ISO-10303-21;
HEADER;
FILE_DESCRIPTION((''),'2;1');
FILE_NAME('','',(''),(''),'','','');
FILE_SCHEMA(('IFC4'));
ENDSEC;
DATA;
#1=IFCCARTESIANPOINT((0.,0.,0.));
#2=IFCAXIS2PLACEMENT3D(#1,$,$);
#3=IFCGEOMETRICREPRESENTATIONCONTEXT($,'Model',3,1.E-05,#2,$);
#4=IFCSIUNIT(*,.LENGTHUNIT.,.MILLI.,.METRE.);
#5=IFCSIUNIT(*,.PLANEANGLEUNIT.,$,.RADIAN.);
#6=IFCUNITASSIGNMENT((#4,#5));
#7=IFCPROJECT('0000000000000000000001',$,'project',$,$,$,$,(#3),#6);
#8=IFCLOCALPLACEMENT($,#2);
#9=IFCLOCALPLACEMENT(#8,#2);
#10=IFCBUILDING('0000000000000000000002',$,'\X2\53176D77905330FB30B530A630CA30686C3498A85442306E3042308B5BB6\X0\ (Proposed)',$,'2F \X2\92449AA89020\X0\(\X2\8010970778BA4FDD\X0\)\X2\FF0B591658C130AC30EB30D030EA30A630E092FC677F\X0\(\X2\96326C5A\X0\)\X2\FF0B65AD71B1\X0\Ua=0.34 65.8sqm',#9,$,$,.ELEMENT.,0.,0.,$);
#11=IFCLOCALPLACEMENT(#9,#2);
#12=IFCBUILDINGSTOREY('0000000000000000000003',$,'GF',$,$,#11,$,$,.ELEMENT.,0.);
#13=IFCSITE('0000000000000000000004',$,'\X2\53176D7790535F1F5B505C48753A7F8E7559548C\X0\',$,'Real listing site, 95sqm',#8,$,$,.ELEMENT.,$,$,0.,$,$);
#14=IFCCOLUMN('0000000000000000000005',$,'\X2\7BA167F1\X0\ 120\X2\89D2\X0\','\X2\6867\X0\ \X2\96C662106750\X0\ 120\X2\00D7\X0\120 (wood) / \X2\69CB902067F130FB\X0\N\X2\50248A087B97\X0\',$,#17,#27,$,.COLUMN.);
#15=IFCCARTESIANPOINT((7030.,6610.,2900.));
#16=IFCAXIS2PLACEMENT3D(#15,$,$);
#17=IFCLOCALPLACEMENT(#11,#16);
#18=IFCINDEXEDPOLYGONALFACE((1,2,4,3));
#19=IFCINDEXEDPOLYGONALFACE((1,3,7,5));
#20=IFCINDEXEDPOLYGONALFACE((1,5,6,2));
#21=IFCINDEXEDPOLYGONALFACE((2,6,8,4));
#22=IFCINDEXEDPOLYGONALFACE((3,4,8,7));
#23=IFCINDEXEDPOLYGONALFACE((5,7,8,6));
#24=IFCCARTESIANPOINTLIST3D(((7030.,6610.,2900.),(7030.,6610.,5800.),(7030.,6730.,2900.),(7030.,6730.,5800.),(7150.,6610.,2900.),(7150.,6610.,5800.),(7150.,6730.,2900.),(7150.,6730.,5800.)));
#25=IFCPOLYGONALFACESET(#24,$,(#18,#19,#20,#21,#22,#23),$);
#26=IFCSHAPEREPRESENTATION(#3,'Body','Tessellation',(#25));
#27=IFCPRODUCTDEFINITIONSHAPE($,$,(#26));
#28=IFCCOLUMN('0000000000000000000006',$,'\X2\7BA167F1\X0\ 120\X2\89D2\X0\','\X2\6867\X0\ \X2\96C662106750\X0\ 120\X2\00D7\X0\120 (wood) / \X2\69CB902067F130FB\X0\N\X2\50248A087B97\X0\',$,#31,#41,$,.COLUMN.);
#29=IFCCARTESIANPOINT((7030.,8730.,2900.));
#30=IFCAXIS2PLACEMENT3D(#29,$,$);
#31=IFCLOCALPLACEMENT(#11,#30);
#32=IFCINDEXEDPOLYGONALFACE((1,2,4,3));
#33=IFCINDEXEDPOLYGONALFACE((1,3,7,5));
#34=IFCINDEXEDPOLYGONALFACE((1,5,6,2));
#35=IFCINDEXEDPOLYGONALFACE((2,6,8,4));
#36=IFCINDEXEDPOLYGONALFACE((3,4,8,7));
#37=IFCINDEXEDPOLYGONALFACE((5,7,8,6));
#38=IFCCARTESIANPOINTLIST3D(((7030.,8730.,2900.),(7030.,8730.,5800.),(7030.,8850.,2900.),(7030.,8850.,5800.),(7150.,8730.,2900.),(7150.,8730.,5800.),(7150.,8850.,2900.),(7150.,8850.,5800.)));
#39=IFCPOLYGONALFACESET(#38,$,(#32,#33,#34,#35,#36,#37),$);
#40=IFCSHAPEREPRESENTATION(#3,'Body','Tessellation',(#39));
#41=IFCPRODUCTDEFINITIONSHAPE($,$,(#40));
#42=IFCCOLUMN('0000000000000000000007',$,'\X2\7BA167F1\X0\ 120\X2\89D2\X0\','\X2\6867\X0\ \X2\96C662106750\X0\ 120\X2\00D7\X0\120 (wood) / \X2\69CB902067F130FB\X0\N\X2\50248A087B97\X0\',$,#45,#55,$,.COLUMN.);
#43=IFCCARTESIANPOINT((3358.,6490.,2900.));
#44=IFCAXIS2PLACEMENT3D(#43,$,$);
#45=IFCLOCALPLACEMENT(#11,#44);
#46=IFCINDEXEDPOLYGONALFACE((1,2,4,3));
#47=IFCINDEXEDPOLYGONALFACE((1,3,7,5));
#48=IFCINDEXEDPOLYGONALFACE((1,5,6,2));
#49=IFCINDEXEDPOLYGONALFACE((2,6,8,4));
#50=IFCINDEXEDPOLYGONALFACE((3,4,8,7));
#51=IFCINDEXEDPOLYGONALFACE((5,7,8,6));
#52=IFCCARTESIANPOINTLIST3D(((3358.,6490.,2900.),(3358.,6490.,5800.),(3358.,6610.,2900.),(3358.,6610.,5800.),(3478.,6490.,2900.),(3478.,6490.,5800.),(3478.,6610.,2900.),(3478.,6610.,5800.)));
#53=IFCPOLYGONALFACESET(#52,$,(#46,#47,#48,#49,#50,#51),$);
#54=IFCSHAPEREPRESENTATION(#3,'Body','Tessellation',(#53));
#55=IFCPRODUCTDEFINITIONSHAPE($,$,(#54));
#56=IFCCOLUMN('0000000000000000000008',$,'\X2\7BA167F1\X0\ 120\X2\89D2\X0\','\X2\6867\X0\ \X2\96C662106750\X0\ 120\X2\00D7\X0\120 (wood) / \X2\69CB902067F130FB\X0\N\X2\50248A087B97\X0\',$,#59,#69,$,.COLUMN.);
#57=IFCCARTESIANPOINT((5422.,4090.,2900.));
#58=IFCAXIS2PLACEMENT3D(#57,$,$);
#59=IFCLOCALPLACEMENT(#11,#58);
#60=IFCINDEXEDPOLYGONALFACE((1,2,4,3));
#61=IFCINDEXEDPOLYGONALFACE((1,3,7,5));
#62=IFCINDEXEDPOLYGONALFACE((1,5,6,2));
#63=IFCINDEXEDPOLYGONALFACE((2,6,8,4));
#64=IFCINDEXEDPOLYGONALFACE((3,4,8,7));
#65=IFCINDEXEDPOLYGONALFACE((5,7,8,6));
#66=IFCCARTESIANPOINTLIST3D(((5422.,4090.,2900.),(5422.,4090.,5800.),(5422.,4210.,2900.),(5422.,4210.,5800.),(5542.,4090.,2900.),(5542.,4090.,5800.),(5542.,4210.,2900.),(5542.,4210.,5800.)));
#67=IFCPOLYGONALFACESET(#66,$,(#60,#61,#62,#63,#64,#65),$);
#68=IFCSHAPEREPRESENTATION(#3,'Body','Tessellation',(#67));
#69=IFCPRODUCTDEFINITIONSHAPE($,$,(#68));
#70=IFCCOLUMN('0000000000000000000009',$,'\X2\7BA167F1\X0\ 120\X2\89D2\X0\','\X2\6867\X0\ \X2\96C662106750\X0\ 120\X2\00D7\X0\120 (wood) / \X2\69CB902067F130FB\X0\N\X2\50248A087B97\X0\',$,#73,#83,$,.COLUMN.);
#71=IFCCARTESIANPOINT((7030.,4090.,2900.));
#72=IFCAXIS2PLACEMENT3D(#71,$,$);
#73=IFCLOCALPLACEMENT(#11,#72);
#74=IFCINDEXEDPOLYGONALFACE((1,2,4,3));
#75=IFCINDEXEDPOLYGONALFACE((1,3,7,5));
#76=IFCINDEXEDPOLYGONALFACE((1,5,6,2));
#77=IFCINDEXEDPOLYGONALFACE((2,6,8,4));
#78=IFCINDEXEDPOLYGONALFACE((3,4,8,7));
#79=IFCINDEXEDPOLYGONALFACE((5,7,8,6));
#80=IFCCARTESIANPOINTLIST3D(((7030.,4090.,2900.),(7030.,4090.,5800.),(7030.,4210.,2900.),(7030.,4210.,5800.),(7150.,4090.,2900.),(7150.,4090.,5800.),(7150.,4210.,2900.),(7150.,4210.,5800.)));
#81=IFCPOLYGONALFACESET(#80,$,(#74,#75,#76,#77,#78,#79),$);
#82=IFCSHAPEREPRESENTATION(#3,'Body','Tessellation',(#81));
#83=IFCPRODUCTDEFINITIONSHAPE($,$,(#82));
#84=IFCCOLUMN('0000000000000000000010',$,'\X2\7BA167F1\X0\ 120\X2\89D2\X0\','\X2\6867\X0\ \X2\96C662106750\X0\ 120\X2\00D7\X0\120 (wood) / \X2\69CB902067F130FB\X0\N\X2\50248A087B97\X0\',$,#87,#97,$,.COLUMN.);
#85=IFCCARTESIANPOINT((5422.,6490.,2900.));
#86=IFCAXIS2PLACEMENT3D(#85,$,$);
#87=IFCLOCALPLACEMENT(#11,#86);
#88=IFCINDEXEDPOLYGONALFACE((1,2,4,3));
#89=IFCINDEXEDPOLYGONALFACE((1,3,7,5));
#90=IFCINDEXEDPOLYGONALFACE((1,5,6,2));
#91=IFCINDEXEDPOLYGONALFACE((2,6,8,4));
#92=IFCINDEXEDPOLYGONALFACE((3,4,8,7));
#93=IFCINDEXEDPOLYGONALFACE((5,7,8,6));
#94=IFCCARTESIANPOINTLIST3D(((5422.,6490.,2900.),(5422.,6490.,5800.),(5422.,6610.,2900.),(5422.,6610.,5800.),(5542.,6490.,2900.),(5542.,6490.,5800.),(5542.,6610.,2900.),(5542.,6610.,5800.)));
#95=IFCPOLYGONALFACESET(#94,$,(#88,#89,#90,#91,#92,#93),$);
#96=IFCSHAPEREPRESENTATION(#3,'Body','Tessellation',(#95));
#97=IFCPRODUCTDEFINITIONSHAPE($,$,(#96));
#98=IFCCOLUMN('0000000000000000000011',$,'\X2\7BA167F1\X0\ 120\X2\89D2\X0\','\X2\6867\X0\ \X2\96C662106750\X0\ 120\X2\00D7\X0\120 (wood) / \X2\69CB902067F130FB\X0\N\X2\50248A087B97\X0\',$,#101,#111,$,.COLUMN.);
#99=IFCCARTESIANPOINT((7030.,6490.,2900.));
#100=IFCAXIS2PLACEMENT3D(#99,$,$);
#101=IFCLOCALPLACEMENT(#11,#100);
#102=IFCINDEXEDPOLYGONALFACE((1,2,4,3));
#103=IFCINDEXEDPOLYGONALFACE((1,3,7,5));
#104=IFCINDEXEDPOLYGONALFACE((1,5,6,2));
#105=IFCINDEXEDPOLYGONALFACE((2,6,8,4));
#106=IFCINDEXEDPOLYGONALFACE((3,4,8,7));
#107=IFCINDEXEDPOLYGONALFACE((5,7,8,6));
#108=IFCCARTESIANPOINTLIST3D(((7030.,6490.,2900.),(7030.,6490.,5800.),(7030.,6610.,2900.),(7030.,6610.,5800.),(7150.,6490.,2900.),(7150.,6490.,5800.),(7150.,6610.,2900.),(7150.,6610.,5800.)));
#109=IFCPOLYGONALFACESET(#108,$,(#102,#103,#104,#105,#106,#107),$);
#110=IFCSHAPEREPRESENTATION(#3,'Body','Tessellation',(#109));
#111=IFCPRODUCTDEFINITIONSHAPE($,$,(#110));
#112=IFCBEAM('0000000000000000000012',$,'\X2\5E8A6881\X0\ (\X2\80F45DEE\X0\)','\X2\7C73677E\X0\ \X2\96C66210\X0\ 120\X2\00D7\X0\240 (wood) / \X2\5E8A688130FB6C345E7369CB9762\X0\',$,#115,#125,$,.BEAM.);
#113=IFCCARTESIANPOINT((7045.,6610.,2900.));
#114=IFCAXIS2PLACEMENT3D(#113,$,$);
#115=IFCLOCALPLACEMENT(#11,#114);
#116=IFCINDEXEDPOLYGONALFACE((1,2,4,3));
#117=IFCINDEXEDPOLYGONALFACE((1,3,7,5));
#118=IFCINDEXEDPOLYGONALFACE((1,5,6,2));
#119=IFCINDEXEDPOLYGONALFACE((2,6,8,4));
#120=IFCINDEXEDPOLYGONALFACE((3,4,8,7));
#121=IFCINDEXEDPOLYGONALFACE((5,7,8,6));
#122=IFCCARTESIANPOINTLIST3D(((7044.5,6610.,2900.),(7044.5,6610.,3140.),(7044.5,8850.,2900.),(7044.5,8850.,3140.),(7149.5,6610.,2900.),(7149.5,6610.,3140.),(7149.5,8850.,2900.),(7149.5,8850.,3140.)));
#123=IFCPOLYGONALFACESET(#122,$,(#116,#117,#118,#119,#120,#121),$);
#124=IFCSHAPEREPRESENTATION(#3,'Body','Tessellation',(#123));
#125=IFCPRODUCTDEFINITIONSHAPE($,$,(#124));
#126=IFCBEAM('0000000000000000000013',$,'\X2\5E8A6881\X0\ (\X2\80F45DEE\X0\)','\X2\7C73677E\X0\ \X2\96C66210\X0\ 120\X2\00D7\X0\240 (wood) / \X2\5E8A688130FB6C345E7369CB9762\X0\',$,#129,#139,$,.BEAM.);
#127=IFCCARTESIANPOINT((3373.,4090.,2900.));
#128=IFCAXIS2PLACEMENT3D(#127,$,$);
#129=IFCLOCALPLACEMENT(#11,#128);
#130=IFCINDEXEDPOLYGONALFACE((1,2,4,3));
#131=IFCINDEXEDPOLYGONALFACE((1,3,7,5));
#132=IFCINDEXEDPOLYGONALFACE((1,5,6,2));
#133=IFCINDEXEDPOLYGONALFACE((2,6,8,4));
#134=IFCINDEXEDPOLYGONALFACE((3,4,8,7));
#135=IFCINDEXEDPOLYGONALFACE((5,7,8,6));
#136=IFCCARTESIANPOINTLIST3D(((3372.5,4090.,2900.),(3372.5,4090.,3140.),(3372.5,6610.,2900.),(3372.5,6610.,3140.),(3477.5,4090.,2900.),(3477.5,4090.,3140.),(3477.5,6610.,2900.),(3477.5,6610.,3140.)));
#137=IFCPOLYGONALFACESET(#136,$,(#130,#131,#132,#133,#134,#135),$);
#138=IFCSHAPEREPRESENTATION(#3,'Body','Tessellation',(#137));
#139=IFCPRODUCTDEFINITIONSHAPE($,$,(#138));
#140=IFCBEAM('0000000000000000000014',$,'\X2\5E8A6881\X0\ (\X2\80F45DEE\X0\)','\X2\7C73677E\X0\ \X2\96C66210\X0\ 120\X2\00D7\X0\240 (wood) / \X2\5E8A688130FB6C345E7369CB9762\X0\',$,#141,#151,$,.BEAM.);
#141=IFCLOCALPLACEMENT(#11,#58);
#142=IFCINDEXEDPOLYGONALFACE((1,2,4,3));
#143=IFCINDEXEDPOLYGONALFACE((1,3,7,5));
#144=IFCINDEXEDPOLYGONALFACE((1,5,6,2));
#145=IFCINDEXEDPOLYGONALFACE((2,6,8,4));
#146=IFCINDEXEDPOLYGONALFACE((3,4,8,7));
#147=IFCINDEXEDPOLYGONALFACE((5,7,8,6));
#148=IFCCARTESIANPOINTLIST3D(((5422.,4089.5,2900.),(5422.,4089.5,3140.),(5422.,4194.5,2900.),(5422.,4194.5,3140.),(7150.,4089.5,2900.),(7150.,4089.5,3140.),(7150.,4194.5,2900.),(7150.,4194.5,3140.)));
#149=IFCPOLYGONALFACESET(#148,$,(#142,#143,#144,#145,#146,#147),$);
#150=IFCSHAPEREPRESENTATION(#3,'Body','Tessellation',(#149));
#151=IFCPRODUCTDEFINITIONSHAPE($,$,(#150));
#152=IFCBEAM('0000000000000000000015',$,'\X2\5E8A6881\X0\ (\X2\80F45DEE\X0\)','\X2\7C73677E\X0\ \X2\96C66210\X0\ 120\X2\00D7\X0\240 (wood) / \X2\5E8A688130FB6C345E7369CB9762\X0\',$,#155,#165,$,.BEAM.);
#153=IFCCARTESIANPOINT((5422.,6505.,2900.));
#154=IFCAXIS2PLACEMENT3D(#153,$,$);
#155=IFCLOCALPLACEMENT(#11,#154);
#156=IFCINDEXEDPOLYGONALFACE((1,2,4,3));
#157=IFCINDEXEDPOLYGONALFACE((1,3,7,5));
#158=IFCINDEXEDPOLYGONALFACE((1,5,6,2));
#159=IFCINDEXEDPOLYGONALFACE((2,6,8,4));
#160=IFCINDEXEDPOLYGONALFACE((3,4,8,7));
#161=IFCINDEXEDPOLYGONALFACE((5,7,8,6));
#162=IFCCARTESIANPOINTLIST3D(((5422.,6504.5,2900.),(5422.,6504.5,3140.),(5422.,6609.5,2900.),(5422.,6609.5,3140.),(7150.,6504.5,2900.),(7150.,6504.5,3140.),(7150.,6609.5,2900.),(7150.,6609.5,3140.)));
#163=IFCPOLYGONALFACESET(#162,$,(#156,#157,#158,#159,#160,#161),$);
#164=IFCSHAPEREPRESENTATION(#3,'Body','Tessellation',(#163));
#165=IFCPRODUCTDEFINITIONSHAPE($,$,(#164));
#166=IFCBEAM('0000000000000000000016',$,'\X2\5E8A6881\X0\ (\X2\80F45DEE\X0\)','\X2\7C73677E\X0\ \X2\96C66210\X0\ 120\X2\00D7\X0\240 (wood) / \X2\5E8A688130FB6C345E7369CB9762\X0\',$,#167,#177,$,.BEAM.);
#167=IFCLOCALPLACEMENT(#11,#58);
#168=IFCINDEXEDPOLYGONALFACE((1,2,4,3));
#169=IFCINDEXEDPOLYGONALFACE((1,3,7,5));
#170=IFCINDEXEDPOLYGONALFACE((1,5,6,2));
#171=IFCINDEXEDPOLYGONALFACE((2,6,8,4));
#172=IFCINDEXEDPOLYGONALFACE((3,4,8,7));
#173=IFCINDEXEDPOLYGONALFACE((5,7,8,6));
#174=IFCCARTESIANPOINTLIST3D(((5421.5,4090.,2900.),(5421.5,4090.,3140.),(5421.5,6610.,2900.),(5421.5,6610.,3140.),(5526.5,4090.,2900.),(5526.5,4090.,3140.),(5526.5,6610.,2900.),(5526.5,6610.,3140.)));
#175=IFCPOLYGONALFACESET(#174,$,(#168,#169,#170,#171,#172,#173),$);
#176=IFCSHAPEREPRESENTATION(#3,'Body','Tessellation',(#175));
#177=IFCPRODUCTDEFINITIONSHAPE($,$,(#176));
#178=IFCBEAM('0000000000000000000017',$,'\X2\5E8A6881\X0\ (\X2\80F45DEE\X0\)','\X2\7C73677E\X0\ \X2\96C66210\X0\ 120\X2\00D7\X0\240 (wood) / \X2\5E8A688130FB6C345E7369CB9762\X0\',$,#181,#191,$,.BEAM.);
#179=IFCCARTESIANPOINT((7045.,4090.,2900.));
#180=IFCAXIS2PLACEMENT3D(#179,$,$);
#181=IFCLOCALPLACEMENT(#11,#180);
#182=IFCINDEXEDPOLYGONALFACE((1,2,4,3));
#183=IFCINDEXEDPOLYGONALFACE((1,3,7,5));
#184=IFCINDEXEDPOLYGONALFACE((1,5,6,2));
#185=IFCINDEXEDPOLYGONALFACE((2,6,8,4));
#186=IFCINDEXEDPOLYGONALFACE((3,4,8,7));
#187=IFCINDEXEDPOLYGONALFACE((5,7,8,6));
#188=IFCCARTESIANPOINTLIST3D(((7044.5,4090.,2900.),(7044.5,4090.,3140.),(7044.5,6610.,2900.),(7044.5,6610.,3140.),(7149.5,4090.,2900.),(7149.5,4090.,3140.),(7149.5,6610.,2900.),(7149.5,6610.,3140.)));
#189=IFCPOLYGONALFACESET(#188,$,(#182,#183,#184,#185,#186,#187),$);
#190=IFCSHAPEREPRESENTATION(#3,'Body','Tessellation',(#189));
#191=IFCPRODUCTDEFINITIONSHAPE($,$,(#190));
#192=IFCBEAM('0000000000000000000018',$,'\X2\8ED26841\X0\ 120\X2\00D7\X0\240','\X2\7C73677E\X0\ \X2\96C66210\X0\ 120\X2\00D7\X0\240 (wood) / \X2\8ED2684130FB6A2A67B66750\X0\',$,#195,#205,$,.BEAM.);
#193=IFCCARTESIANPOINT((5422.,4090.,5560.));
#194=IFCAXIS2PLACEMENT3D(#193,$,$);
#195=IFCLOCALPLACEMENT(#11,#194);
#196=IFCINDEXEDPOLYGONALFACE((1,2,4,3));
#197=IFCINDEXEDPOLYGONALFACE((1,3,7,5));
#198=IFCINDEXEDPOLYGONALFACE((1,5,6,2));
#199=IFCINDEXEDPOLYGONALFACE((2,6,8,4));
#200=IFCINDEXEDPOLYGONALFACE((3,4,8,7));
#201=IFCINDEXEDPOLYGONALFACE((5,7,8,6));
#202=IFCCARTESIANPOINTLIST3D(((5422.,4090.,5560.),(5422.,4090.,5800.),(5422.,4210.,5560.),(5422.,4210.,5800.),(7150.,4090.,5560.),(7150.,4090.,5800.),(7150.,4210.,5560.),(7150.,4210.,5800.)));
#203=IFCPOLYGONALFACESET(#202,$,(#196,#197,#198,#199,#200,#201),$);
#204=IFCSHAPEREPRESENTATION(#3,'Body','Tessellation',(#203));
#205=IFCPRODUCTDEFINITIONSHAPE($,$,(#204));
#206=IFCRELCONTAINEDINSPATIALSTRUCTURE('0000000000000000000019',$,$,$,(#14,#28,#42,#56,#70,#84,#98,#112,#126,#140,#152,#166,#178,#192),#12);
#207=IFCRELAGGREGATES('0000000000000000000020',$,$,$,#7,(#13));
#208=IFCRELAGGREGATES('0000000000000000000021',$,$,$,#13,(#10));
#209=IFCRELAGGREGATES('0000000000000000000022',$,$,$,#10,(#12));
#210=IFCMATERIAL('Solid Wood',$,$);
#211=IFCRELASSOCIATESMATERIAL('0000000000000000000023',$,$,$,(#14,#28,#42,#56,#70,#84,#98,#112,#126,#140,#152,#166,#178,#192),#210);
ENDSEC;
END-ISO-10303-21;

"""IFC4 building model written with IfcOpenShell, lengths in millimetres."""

from ifc_helpers import new_model, si_unit, frame, frame_2d, origin, place, context, project, spatial, rectangle, extrude, material, element, save


model = new_model("IFC4")

# Units and contexts
model_context = context("Model", 3, precision=1e-05, world=origin())
ifc_project = project(units=[si_unit("LENGTHUNIT", "METRE", prefix="MILLI"), si_unit("PLANEANGLEUNIT", "RADIAN")], contexts=[model_context])

# Site, building, storey
site_placement = place(None, origin())
site = spatial("IfcSite", under=ifc_project, at=site_placement, Name="北海道弟子屈町美留和", ObjectType="Real listing site, 95sqm", CompositionType="ELEMENT", RefElevation=0.0)
building_placement = place(site_placement, origin())
building = spatial("IfcBuilding", under=site, at=building_placement, Name="北海道・サウナと水風呂のある家 (Proposed)", ObjectType="2F 鉄骨造(耐震確保)＋外壁ガルバリウム鋼板(防汚)＋断熱Ua=0.34 65.8sqm", CompositionType="ELEMENT", ElevationOfRefHeight=0.0, ElevationOfTerrain=0.0)
storey_placement = place(building_placement, origin())
storey = spatial("IfcBuildingStorey", under=building, at=storey_placement, Name="GF", CompositionType="ELEMENT", Elevation=0.0)

# Columns
ifc_material_1 = material(Name="Solid Wood")
column_1_placement = place(storey_placement, frame((7030.0, 6610.0, 2900.0)))
element("IfcColumn", 1, at=column_1_placement, inside=storey, material=ifc_material_1, Name="管柱 120角", Description="桧 集成材 120×120 (wood) / 構造柱・N値計算", PredefinedType="COLUMN", context=model_context, shape_type="SweptSolid", body=[
    extrude(rectangle(XDim=120.0, YDim=120.0, at=frame_2d((60.0, 60.0))), frame((7030.0, 6610.0, 2900.0)), (0.0, 0.0, 1.0), 2900.0),
])
column_2_placement = place(storey_placement, frame((7030.0, 8730.0, 2900.0)))
element("IfcColumn", 2, at=column_2_placement, inside=storey, material=ifc_material_1, Name="管柱 120角", Description="桧 集成材 120×120 (wood) / 構造柱・N値計算", PredefinedType="COLUMN", context=model_context, shape_type="SweptSolid", body=[
    extrude(rectangle(XDim=120.0, YDim=120.0, at=frame_2d((60.0, 60.0))), frame((7030.0, 8730.0, 2900.0)), (0.0, 0.0, 1.0), 2900.0),
])
column_3_placement = place(storey_placement, frame((3358.0, 6490.0, 2900.0)))
element("IfcColumn", 3, at=column_3_placement, inside=storey, material=ifc_material_1, Name="管柱 120角", Description="桧 集成材 120×120 (wood) / 構造柱・N値計算", PredefinedType="COLUMN", context=model_context, shape_type="SweptSolid", body=[
    extrude(rectangle(XDim=120.0, YDim=120.0, at=frame_2d((60.0, 60.0))), frame((3358.0, 6490.0, 2900.0)), (0.0, 0.0, 1.0), 2900.0),
])
column_4_placement = place(storey_placement, frame((5422.0, 4090.0, 2900.0)))
element("IfcColumn", 4, at=column_4_placement, inside=storey, material=ifc_material_1, Name="管柱 120角", Description="桧 集成材 120×120 (wood) / 構造柱・N値計算", PredefinedType="COLUMN", context=model_context, shape_type="SweptSolid", body=[
    extrude(rectangle(XDim=120.0, YDim=120.0, at=frame_2d((60.0, 60.0))), frame((5422.0, 4090.0, 2900.0)), (0.0, 0.0, 1.0), 2900.0),
])
column_5_placement = place(storey_placement, frame((7030.0, 4090.0, 2900.0)))
element("IfcColumn", 5, at=column_5_placement, inside=storey, material=ifc_material_1, Name="管柱 120角", Description="桧 集成材 120×120 (wood) / 構造柱・N値計算", PredefinedType="COLUMN", context=model_context, shape_type="SweptSolid", body=[
    extrude(rectangle(XDim=120.0, YDim=120.0, at=frame_2d((60.0, 60.0))), frame((7030.0, 4090.0, 2900.0)), (0.0, 0.0, 1.0), 2900.0),
])
column_6_placement = place(storey_placement, frame((5422.0, 6490.0, 2900.0)))
element("IfcColumn", 6, at=column_6_placement, inside=storey, material=ifc_material_1, Name="管柱 120角", Description="桧 集成材 120×120 (wood) / 構造柱・N値計算", PredefinedType="COLUMN", context=model_context, shape_type="SweptSolid", body=[
    extrude(rectangle(XDim=120.0, YDim=120.0, at=frame_2d((60.0, 60.0))), frame((5422.0, 6490.0, 2900.0)), (0.0, 0.0, 1.0), 2900.0),
])
column_7_placement = place(storey_placement, frame((7030.0, 6490.0, 2900.0)))
element("IfcColumn", 7, at=column_7_placement, inside=storey, material=ifc_material_1, Name="管柱 120角", Description="桧 集成材 120×120 (wood) / 構造柱・N値計算", PredefinedType="COLUMN", context=model_context, shape_type="SweptSolid", body=[
    extrude(rectangle(XDim=120.0, YDim=120.0, at=frame_2d((60.0, 60.0))), frame((7030.0, 6490.0, 2900.0)), (0.0, 0.0, 1.0), 2900.0),
])

# Beams
beam_1_placement = place(storey_placement, frame((7045.0, 6610.0, 2900.0)))
element("IfcBeam", 8, at=beam_1_placement, inside=storey, material=ifc_material_1, Name="床梁 (胴差)", Description="米松 集成 120×240 (wood) / 床梁・水平構面", PredefinedType="BEAM", context=model_context, shape_type="SweptSolid", body=[
    extrude(rectangle(XDim=105.0, YDim=2240.0, at=frame_2d((52.0, 1120.0))), frame((7045.0, 6610.0, 2900.0)), (0.0, 0.0, 1.0), 240.0),
])
beam_2_placement = place(storey_placement, frame((3373.0, 4090.0, 2900.0)))
element("IfcBeam", 9, at=beam_2_placement, inside=storey, material=ifc_material_1, Name="床梁 (胴差)", Description="米松 集成 120×240 (wood) / 床梁・水平構面", PredefinedType="BEAM", context=model_context, shape_type="SweptSolid", body=[
    extrude(rectangle(XDim=105.0, YDim=2520.0, at=frame_2d((52.0, 1260.0))), frame((3373.0, 4090.0, 2900.0)), (0.0, 0.0, 1.0), 240.0),
])
beam_3_placement = place(storey_placement, frame((5422.0, 4090.0, 2900.0)))
element("IfcBeam", 10, at=beam_3_placement, inside=storey, material=ifc_material_1, Name="床梁 (胴差)", Description="米松 集成 120×240 (wood) / 床梁・水平構面", PredefinedType="BEAM", context=model_context, shape_type="SweptSolid", body=[
    extrude(rectangle(XDim=1728.0, YDim=105.0, at=frame_2d((864.0, 52.0))), frame((5422.0, 4090.0, 2900.0)), (0.0, 0.0, 1.0), 240.0),
])
beam_4_placement = place(storey_placement, frame((5422.0, 6505.0, 2900.0)))
element("IfcBeam", 11, at=beam_4_placement, inside=storey, material=ifc_material_1, Name="床梁 (胴差)", Description="米松 集成 120×240 (wood) / 床梁・水平構面", PredefinedType="BEAM", context=model_context, shape_type="SweptSolid", body=[
    extrude(rectangle(XDim=1728.0, YDim=105.0, at=frame_2d((864.0, 52.0))), frame((5422.0, 6505.0, 2900.0)), (0.0, 0.0, 1.0), 240.0),
])
beam_5_placement = place(storey_placement, frame((5422.0, 4090.0, 2900.0)))
element("IfcBeam", 12, at=beam_5_placement, inside=storey, material=ifc_material_1, Name="床梁 (胴差)", Description="米松 集成 120×240 (wood) / 床梁・水平構面", PredefinedType="BEAM", context=model_context, shape_type="SweptSolid", body=[
    extrude(rectangle(XDim=105.0, YDim=2520.0, at=frame_2d((52.0, 1260.0))), frame((5422.0, 4090.0, 2900.0)), (0.0, 0.0, 1.0), 240.0),
])
beam_6_placement = place(storey_placement, frame((7045.0, 4090.0, 2900.0)))
element("IfcBeam", 13, at=beam_6_placement, inside=storey, material=ifc_material_1, Name="床梁 (胴差)", Description="米松 集成 120×240 (wood) / 床梁・水平構面", PredefinedType="BEAM", context=model_context, shape_type="SweptSolid", body=[
    extrude(rectangle(XDim=105.0, YDim=2520.0, at=frame_2d((52.0, 1260.0))), frame((7045.0, 4090.0, 2900.0)), (0.0, 0.0, 1.0), 240.0),
])
beam_7_placement = place(storey_placement, frame((5422.0, 4090.0, 5560.0)))
element("IfcBeam", 14, at=beam_7_placement, inside=storey, material=ifc_material_1, Name="軒桁 120×240", Description="米松 集成 120×240 (wood) / 軒桁・横架材", PredefinedType="BEAM", context=model_context, shape_type="SweptSolid", body=[
    extrude(rectangle(XDim=1728.0, YDim=120.0, at=frame_2d((864.0, 60.0))), frame((5422.0, 4090.0, 5560.0)), (0.0, 0.0, 1.0), 240.0),
])

save(model, "model.ifc")
